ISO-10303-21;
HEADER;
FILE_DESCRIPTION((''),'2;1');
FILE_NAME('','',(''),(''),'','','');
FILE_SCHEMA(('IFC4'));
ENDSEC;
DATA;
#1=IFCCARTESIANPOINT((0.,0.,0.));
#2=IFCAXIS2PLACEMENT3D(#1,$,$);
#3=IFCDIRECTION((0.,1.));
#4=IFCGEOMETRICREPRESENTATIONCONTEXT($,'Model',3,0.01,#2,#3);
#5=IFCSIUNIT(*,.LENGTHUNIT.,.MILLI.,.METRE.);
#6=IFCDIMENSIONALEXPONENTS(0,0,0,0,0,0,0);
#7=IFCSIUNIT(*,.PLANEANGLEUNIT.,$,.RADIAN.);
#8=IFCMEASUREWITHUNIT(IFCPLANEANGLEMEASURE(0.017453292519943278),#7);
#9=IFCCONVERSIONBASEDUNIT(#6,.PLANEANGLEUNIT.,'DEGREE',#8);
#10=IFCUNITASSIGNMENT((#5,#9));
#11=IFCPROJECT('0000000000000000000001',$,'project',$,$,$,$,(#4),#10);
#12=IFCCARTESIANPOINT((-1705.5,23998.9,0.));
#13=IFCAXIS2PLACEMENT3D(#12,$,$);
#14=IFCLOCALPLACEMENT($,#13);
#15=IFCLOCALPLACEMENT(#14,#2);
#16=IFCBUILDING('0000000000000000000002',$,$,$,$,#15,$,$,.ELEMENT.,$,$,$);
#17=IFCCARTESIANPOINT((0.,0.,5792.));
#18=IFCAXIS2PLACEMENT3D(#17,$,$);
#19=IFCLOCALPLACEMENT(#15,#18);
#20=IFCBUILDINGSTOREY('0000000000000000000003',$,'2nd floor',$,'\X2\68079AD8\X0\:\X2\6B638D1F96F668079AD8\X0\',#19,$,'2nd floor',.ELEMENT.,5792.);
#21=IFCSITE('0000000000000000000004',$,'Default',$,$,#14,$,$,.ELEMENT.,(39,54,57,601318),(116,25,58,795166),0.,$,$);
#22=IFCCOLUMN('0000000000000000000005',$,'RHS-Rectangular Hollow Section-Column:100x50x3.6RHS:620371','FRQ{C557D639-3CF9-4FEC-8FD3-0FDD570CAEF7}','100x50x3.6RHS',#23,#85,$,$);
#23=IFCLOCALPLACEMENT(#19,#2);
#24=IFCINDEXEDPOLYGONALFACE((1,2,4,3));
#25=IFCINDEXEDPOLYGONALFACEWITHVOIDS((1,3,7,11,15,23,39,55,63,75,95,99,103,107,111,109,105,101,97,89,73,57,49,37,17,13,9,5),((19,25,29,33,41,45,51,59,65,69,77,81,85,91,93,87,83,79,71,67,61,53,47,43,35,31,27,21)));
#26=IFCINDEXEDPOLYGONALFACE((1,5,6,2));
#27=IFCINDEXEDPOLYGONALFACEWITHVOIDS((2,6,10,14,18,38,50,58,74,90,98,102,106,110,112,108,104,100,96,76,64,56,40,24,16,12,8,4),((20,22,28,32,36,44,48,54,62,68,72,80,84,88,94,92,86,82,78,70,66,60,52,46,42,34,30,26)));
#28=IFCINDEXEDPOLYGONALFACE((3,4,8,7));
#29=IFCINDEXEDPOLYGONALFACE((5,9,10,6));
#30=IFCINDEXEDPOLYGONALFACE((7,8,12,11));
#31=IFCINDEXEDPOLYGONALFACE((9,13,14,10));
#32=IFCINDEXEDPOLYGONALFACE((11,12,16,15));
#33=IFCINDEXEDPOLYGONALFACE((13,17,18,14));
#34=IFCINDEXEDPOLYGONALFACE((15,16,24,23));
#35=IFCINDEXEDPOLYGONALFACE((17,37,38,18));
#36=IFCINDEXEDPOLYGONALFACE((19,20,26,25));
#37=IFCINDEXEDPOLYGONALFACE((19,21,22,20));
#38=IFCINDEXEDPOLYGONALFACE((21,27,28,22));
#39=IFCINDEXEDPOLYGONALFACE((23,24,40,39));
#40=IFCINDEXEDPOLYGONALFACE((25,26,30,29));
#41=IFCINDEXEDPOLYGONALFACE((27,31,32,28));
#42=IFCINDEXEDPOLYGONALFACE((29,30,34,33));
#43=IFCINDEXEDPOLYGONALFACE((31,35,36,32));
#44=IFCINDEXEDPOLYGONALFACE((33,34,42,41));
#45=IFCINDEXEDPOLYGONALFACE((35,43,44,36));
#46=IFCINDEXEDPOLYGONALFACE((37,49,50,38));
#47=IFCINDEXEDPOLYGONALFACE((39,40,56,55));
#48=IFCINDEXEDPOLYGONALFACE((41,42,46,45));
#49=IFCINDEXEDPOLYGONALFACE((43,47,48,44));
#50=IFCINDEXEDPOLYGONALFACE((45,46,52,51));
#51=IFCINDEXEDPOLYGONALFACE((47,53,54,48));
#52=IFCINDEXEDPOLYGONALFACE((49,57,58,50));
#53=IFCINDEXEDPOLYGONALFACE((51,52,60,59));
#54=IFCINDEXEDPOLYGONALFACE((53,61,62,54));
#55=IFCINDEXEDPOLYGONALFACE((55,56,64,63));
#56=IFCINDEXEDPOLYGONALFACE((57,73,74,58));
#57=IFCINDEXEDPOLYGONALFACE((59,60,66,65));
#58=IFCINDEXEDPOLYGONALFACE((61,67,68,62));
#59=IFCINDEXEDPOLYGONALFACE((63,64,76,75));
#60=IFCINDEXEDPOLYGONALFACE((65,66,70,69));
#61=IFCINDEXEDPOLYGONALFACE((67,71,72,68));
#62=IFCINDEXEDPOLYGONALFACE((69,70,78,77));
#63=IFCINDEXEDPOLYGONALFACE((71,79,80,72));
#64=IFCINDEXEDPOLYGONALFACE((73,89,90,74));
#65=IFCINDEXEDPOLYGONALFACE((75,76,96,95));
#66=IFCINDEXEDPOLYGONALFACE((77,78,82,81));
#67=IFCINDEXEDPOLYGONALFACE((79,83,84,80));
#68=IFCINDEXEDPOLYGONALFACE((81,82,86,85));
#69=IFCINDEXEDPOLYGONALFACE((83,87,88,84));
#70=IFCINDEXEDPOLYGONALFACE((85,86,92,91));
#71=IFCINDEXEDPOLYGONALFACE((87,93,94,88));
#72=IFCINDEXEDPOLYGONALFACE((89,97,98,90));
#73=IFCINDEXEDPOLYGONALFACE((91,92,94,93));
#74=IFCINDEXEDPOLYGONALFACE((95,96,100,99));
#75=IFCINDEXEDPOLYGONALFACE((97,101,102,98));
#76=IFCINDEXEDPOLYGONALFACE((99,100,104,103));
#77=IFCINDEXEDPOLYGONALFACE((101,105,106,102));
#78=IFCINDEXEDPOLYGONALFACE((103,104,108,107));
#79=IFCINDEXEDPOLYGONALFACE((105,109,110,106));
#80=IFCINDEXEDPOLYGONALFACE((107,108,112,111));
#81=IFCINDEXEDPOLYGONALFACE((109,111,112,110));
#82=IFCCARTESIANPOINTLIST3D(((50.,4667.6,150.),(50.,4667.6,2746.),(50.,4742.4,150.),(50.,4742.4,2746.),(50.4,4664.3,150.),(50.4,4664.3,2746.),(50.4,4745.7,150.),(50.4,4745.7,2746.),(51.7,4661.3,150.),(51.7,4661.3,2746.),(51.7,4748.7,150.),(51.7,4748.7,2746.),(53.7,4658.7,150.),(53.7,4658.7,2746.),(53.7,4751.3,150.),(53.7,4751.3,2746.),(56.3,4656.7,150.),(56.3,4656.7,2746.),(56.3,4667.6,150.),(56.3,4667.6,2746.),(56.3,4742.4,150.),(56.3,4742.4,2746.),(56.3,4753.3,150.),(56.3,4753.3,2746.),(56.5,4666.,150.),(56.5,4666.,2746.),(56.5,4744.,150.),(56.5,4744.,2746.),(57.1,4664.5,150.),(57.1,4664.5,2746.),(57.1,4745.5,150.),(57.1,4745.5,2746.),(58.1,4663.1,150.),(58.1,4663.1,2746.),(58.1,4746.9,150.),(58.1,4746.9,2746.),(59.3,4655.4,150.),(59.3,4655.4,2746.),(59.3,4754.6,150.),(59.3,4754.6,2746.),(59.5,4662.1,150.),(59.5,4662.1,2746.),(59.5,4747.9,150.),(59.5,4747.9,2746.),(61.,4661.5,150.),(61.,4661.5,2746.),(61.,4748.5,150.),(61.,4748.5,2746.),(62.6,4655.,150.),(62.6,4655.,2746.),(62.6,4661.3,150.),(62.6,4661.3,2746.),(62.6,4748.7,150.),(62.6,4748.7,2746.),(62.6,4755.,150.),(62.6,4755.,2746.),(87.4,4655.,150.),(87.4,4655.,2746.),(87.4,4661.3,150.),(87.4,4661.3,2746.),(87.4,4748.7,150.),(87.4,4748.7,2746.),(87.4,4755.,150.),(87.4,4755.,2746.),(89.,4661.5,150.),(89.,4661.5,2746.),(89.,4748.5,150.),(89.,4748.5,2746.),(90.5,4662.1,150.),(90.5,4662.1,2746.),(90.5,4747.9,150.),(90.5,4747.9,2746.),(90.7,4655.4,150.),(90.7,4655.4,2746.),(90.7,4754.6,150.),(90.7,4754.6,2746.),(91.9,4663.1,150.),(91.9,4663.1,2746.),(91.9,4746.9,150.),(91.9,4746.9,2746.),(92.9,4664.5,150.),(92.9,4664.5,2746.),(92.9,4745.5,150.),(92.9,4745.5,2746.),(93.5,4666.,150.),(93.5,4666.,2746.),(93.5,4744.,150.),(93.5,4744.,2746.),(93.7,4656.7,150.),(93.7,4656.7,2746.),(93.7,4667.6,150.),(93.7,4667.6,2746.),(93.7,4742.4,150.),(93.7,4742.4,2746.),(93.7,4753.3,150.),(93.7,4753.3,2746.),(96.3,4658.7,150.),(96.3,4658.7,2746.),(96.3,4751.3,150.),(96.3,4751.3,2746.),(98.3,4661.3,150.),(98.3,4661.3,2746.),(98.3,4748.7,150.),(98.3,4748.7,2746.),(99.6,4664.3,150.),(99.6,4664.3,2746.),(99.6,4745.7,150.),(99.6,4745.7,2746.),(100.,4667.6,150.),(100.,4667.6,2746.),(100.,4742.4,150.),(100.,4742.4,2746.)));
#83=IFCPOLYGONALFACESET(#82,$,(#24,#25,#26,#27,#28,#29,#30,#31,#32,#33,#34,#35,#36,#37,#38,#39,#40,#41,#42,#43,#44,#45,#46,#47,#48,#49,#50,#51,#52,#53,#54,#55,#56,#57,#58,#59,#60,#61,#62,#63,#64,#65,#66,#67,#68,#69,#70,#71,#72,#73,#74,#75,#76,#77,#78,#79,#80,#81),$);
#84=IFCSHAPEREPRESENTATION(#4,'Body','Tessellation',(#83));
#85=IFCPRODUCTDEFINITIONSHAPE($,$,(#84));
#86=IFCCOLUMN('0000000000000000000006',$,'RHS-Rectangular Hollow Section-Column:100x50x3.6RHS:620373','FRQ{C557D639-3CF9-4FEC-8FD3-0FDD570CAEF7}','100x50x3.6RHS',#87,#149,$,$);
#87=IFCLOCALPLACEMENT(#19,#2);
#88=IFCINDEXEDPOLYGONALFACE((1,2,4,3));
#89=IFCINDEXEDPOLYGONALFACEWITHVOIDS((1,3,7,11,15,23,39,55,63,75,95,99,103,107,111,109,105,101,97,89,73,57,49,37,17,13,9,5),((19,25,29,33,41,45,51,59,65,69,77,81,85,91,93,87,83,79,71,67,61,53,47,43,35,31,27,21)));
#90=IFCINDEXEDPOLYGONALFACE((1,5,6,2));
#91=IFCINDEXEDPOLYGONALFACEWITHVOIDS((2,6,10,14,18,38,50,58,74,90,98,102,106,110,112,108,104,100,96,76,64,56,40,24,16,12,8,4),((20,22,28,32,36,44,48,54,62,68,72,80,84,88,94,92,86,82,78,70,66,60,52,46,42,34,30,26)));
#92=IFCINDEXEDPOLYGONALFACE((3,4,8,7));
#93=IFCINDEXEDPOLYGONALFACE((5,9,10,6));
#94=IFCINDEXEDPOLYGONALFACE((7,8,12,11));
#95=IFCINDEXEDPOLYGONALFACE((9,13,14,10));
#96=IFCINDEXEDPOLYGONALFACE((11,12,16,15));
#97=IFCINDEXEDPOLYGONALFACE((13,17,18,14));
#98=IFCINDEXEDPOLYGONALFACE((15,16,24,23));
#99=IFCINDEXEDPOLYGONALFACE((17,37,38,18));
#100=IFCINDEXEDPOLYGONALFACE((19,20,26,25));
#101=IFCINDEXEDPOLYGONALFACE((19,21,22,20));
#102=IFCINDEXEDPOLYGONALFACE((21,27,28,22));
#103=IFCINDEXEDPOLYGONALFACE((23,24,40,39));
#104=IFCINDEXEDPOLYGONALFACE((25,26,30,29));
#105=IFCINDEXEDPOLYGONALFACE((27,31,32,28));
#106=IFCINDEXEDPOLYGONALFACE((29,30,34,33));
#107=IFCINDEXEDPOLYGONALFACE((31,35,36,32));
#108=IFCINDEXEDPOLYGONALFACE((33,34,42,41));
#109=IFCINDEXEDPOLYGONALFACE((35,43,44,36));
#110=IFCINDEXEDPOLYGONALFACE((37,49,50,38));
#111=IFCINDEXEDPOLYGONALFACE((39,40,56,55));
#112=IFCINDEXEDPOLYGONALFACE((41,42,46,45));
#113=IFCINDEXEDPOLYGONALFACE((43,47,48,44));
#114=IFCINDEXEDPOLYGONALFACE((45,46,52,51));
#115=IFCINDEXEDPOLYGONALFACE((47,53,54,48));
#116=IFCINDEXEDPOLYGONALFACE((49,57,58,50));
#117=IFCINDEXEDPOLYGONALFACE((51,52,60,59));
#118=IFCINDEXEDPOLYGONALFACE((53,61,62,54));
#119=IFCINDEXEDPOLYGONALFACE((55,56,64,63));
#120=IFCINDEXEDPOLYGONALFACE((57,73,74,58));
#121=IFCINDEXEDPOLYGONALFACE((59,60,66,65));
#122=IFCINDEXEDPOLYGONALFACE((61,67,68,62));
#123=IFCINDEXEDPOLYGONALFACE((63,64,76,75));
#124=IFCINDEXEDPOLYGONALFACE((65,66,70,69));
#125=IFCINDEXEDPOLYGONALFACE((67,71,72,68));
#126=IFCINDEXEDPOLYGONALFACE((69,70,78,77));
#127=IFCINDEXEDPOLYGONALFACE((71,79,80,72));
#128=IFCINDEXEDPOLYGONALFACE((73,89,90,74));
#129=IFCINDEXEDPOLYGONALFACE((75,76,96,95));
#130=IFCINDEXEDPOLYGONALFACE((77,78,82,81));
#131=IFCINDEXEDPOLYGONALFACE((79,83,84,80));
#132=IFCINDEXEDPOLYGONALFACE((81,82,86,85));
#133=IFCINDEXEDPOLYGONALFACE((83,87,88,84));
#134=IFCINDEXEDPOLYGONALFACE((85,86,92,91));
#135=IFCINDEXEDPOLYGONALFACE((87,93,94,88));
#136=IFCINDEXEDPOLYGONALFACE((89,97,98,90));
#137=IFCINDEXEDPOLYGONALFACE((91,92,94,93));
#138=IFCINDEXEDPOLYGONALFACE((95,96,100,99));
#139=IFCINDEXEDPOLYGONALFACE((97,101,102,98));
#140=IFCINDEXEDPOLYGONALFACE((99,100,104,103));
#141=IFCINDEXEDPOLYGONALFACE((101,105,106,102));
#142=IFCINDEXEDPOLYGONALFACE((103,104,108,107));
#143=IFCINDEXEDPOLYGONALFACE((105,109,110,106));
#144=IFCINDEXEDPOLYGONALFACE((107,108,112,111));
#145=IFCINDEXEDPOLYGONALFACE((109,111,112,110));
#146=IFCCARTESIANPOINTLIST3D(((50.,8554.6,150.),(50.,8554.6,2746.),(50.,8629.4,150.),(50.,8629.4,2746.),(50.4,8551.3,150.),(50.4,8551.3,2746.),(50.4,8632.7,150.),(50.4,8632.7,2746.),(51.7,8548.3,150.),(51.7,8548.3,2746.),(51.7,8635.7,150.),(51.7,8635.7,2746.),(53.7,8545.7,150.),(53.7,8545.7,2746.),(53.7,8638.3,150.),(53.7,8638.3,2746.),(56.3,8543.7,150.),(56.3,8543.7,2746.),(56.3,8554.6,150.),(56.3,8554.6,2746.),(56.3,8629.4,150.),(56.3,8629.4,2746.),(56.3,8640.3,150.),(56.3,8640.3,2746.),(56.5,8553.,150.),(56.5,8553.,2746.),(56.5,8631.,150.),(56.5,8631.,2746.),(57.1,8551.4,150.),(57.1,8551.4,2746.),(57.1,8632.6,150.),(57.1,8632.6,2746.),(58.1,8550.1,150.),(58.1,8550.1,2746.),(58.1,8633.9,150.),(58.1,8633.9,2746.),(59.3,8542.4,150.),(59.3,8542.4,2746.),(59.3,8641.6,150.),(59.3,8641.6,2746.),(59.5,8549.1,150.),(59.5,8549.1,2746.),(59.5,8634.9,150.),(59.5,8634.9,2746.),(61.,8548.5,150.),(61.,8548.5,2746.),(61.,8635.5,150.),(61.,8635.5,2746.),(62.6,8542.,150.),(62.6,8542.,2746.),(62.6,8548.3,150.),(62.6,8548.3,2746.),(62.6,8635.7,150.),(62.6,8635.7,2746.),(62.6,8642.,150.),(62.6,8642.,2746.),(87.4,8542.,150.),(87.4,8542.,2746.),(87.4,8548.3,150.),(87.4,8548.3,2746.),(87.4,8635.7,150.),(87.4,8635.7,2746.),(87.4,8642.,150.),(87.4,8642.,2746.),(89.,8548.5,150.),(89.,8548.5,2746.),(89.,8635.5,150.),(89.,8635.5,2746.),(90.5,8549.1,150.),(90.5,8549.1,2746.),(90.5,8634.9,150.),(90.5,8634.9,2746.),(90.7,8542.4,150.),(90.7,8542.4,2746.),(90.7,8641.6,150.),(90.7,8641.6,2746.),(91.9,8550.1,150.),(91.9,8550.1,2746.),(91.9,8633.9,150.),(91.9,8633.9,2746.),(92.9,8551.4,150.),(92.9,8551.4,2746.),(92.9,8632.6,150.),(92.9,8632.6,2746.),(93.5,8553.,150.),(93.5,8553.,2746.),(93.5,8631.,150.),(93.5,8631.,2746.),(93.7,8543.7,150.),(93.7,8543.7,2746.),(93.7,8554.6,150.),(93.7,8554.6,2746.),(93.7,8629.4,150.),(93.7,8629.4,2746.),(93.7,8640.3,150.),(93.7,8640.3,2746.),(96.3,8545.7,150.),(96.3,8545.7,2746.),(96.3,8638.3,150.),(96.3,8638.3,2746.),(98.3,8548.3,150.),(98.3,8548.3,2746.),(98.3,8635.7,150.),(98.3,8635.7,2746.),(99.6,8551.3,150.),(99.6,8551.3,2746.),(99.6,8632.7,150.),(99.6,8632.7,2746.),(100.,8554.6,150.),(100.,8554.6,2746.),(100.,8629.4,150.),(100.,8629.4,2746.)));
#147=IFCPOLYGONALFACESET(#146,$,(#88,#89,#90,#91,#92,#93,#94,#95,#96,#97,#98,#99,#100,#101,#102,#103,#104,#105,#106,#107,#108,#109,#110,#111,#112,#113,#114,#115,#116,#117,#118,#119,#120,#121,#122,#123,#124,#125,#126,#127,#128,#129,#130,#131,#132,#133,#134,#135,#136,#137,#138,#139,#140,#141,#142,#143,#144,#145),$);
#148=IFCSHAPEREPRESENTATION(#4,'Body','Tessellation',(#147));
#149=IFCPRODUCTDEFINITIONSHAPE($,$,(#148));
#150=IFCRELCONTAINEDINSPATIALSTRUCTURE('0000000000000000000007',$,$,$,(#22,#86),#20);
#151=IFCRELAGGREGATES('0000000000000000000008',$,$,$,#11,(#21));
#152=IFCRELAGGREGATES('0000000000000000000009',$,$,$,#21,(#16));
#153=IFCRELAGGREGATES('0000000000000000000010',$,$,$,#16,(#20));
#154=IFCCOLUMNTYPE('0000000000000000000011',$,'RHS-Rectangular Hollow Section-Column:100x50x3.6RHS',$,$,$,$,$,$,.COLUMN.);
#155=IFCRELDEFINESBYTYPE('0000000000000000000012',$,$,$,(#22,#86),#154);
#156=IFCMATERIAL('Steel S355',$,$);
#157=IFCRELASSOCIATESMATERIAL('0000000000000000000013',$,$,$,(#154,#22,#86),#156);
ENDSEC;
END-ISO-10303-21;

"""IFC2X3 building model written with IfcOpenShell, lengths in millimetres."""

from ifc_helpers import new_model, entity, si_unit, converted_unit, direction, frame, origin, origin_2d, place, context, project, spatial, hollow_rectangle, extrude, clip, halfspace, material, type_object, element, save


model = new_model("IFC2X3")

# Units and contexts
model_context = context("Model", 3, precision=0.01, world=origin(), true_north=direction((0.0, 1.0)))
ifc_project = project(units=[si_unit("LENGTHUNIT", "METRE", prefix="MILLI"), converted_unit("PLANEANGLEUNIT", "DEGREE", entity("IfcPlaneAngleMeasure", 0.017453292519943278), si_unit("PLANEANGLEUNIT", "RADIAN"), dimensions=[0, 0, 0, 0, 0, 0, 0])], contexts=[model_context])

# Site, building, storey
site_placement = place(None, frame((-1705.5, 23998.9, 0.0)))
site = spatial("IfcSite", under=ifc_project, at=site_placement, Name="Default", CompositionType="ELEMENT", RefLatitude=(39, 54, 57, 601318), RefLongitude=(116, 25, 58, 795166), RefElevation=0.0)
building_placement = place(site_placement, origin())
building = spatial("IfcBuilding", under=site, at=building_placement, CompositionType="ELEMENT")
storey_placement = place(building_placement, frame((0.0, 0.0, 5792.0)))
storey = spatial("IfcBuildingStorey", under=building, at=storey_placement, Name="2nd floor", ObjectType="标高:正负零标高", LongName="2nd floor", CompositionType="ELEMENT", Elevation=5792.0)

# Columns
ifc_material_1 = material(Name="Steel S355")
column_type = type_object("IfcColumnType", Name="RHS-Rectangular Hollow Section-Column:100x50x3.6RHS", PredefinedType="COLUMN", material=ifc_material_1)
column_1_placement = place(storey_placement, frame((75.0, 4705.0, 2746.0), z_axis=(0.0, 0.0, 1.0), x_axis=(-1.0, 0.0, 0.0)))
element("IfcColumn", 1, at=column_1_placement, inside=storey, type_object=column_type, material=ifc_material_1, Name="RHS-Rectangular Hollow Section-Column:100x50x3.6RHS:620371", Description="FRQ{C557D639-3CF9-4FEC-8FD3-0FDD570CAEF7}", ObjectType="100x50x3.6RHS", context=model_context, shape_type="Clipping", body=[
    clip(extrude(hollow_rectangle(XDim=50.0, YDim=100.0, WallThickness=6.3, InnerFilletRadius=6.3, OuterFilletRadius=12.6, at=origin_2d()), origin(), (0.0, 0.0, -1.0), 2651.9), halfspace(frame((75.0, 4705.0, -2596.0), z_axis=(0.0, 0.0, 1.0), x_axis=(-1.0, 0.0, 0.0)), True)),
])
column_2_placement = place(storey_placement, frame((75.0, 8592.0, 2746.0), z_axis=(0.0, 0.0, 1.0), x_axis=(-1.0, 0.0, 0.0)))
element("IfcColumn", 2, at=column_2_placement, inside=storey, type_object=column_type, material=ifc_material_1, Name="RHS-Rectangular Hollow Section-Column:100x50x3.6RHS:620373", Description="FRQ{C557D639-3CF9-4FEC-8FD3-0FDD570CAEF7}", ObjectType="100x50x3.6RHS", context=model_context, shape_type="Clipping", body=[
    clip(extrude(hollow_rectangle(XDim=50.0, YDim=100.0, WallThickness=6.3, InnerFilletRadius=6.3, OuterFilletRadius=12.6, at=origin_2d()), origin(), (0.0, 0.0, -1.0), 2651.9), halfspace(frame((75.0, 8592.0, -2596.0), z_axis=(0.0, 0.0, 1.0), x_axis=(-1.0, 0.0, 0.0)), True)),
])

save(model, "model.ifc")
